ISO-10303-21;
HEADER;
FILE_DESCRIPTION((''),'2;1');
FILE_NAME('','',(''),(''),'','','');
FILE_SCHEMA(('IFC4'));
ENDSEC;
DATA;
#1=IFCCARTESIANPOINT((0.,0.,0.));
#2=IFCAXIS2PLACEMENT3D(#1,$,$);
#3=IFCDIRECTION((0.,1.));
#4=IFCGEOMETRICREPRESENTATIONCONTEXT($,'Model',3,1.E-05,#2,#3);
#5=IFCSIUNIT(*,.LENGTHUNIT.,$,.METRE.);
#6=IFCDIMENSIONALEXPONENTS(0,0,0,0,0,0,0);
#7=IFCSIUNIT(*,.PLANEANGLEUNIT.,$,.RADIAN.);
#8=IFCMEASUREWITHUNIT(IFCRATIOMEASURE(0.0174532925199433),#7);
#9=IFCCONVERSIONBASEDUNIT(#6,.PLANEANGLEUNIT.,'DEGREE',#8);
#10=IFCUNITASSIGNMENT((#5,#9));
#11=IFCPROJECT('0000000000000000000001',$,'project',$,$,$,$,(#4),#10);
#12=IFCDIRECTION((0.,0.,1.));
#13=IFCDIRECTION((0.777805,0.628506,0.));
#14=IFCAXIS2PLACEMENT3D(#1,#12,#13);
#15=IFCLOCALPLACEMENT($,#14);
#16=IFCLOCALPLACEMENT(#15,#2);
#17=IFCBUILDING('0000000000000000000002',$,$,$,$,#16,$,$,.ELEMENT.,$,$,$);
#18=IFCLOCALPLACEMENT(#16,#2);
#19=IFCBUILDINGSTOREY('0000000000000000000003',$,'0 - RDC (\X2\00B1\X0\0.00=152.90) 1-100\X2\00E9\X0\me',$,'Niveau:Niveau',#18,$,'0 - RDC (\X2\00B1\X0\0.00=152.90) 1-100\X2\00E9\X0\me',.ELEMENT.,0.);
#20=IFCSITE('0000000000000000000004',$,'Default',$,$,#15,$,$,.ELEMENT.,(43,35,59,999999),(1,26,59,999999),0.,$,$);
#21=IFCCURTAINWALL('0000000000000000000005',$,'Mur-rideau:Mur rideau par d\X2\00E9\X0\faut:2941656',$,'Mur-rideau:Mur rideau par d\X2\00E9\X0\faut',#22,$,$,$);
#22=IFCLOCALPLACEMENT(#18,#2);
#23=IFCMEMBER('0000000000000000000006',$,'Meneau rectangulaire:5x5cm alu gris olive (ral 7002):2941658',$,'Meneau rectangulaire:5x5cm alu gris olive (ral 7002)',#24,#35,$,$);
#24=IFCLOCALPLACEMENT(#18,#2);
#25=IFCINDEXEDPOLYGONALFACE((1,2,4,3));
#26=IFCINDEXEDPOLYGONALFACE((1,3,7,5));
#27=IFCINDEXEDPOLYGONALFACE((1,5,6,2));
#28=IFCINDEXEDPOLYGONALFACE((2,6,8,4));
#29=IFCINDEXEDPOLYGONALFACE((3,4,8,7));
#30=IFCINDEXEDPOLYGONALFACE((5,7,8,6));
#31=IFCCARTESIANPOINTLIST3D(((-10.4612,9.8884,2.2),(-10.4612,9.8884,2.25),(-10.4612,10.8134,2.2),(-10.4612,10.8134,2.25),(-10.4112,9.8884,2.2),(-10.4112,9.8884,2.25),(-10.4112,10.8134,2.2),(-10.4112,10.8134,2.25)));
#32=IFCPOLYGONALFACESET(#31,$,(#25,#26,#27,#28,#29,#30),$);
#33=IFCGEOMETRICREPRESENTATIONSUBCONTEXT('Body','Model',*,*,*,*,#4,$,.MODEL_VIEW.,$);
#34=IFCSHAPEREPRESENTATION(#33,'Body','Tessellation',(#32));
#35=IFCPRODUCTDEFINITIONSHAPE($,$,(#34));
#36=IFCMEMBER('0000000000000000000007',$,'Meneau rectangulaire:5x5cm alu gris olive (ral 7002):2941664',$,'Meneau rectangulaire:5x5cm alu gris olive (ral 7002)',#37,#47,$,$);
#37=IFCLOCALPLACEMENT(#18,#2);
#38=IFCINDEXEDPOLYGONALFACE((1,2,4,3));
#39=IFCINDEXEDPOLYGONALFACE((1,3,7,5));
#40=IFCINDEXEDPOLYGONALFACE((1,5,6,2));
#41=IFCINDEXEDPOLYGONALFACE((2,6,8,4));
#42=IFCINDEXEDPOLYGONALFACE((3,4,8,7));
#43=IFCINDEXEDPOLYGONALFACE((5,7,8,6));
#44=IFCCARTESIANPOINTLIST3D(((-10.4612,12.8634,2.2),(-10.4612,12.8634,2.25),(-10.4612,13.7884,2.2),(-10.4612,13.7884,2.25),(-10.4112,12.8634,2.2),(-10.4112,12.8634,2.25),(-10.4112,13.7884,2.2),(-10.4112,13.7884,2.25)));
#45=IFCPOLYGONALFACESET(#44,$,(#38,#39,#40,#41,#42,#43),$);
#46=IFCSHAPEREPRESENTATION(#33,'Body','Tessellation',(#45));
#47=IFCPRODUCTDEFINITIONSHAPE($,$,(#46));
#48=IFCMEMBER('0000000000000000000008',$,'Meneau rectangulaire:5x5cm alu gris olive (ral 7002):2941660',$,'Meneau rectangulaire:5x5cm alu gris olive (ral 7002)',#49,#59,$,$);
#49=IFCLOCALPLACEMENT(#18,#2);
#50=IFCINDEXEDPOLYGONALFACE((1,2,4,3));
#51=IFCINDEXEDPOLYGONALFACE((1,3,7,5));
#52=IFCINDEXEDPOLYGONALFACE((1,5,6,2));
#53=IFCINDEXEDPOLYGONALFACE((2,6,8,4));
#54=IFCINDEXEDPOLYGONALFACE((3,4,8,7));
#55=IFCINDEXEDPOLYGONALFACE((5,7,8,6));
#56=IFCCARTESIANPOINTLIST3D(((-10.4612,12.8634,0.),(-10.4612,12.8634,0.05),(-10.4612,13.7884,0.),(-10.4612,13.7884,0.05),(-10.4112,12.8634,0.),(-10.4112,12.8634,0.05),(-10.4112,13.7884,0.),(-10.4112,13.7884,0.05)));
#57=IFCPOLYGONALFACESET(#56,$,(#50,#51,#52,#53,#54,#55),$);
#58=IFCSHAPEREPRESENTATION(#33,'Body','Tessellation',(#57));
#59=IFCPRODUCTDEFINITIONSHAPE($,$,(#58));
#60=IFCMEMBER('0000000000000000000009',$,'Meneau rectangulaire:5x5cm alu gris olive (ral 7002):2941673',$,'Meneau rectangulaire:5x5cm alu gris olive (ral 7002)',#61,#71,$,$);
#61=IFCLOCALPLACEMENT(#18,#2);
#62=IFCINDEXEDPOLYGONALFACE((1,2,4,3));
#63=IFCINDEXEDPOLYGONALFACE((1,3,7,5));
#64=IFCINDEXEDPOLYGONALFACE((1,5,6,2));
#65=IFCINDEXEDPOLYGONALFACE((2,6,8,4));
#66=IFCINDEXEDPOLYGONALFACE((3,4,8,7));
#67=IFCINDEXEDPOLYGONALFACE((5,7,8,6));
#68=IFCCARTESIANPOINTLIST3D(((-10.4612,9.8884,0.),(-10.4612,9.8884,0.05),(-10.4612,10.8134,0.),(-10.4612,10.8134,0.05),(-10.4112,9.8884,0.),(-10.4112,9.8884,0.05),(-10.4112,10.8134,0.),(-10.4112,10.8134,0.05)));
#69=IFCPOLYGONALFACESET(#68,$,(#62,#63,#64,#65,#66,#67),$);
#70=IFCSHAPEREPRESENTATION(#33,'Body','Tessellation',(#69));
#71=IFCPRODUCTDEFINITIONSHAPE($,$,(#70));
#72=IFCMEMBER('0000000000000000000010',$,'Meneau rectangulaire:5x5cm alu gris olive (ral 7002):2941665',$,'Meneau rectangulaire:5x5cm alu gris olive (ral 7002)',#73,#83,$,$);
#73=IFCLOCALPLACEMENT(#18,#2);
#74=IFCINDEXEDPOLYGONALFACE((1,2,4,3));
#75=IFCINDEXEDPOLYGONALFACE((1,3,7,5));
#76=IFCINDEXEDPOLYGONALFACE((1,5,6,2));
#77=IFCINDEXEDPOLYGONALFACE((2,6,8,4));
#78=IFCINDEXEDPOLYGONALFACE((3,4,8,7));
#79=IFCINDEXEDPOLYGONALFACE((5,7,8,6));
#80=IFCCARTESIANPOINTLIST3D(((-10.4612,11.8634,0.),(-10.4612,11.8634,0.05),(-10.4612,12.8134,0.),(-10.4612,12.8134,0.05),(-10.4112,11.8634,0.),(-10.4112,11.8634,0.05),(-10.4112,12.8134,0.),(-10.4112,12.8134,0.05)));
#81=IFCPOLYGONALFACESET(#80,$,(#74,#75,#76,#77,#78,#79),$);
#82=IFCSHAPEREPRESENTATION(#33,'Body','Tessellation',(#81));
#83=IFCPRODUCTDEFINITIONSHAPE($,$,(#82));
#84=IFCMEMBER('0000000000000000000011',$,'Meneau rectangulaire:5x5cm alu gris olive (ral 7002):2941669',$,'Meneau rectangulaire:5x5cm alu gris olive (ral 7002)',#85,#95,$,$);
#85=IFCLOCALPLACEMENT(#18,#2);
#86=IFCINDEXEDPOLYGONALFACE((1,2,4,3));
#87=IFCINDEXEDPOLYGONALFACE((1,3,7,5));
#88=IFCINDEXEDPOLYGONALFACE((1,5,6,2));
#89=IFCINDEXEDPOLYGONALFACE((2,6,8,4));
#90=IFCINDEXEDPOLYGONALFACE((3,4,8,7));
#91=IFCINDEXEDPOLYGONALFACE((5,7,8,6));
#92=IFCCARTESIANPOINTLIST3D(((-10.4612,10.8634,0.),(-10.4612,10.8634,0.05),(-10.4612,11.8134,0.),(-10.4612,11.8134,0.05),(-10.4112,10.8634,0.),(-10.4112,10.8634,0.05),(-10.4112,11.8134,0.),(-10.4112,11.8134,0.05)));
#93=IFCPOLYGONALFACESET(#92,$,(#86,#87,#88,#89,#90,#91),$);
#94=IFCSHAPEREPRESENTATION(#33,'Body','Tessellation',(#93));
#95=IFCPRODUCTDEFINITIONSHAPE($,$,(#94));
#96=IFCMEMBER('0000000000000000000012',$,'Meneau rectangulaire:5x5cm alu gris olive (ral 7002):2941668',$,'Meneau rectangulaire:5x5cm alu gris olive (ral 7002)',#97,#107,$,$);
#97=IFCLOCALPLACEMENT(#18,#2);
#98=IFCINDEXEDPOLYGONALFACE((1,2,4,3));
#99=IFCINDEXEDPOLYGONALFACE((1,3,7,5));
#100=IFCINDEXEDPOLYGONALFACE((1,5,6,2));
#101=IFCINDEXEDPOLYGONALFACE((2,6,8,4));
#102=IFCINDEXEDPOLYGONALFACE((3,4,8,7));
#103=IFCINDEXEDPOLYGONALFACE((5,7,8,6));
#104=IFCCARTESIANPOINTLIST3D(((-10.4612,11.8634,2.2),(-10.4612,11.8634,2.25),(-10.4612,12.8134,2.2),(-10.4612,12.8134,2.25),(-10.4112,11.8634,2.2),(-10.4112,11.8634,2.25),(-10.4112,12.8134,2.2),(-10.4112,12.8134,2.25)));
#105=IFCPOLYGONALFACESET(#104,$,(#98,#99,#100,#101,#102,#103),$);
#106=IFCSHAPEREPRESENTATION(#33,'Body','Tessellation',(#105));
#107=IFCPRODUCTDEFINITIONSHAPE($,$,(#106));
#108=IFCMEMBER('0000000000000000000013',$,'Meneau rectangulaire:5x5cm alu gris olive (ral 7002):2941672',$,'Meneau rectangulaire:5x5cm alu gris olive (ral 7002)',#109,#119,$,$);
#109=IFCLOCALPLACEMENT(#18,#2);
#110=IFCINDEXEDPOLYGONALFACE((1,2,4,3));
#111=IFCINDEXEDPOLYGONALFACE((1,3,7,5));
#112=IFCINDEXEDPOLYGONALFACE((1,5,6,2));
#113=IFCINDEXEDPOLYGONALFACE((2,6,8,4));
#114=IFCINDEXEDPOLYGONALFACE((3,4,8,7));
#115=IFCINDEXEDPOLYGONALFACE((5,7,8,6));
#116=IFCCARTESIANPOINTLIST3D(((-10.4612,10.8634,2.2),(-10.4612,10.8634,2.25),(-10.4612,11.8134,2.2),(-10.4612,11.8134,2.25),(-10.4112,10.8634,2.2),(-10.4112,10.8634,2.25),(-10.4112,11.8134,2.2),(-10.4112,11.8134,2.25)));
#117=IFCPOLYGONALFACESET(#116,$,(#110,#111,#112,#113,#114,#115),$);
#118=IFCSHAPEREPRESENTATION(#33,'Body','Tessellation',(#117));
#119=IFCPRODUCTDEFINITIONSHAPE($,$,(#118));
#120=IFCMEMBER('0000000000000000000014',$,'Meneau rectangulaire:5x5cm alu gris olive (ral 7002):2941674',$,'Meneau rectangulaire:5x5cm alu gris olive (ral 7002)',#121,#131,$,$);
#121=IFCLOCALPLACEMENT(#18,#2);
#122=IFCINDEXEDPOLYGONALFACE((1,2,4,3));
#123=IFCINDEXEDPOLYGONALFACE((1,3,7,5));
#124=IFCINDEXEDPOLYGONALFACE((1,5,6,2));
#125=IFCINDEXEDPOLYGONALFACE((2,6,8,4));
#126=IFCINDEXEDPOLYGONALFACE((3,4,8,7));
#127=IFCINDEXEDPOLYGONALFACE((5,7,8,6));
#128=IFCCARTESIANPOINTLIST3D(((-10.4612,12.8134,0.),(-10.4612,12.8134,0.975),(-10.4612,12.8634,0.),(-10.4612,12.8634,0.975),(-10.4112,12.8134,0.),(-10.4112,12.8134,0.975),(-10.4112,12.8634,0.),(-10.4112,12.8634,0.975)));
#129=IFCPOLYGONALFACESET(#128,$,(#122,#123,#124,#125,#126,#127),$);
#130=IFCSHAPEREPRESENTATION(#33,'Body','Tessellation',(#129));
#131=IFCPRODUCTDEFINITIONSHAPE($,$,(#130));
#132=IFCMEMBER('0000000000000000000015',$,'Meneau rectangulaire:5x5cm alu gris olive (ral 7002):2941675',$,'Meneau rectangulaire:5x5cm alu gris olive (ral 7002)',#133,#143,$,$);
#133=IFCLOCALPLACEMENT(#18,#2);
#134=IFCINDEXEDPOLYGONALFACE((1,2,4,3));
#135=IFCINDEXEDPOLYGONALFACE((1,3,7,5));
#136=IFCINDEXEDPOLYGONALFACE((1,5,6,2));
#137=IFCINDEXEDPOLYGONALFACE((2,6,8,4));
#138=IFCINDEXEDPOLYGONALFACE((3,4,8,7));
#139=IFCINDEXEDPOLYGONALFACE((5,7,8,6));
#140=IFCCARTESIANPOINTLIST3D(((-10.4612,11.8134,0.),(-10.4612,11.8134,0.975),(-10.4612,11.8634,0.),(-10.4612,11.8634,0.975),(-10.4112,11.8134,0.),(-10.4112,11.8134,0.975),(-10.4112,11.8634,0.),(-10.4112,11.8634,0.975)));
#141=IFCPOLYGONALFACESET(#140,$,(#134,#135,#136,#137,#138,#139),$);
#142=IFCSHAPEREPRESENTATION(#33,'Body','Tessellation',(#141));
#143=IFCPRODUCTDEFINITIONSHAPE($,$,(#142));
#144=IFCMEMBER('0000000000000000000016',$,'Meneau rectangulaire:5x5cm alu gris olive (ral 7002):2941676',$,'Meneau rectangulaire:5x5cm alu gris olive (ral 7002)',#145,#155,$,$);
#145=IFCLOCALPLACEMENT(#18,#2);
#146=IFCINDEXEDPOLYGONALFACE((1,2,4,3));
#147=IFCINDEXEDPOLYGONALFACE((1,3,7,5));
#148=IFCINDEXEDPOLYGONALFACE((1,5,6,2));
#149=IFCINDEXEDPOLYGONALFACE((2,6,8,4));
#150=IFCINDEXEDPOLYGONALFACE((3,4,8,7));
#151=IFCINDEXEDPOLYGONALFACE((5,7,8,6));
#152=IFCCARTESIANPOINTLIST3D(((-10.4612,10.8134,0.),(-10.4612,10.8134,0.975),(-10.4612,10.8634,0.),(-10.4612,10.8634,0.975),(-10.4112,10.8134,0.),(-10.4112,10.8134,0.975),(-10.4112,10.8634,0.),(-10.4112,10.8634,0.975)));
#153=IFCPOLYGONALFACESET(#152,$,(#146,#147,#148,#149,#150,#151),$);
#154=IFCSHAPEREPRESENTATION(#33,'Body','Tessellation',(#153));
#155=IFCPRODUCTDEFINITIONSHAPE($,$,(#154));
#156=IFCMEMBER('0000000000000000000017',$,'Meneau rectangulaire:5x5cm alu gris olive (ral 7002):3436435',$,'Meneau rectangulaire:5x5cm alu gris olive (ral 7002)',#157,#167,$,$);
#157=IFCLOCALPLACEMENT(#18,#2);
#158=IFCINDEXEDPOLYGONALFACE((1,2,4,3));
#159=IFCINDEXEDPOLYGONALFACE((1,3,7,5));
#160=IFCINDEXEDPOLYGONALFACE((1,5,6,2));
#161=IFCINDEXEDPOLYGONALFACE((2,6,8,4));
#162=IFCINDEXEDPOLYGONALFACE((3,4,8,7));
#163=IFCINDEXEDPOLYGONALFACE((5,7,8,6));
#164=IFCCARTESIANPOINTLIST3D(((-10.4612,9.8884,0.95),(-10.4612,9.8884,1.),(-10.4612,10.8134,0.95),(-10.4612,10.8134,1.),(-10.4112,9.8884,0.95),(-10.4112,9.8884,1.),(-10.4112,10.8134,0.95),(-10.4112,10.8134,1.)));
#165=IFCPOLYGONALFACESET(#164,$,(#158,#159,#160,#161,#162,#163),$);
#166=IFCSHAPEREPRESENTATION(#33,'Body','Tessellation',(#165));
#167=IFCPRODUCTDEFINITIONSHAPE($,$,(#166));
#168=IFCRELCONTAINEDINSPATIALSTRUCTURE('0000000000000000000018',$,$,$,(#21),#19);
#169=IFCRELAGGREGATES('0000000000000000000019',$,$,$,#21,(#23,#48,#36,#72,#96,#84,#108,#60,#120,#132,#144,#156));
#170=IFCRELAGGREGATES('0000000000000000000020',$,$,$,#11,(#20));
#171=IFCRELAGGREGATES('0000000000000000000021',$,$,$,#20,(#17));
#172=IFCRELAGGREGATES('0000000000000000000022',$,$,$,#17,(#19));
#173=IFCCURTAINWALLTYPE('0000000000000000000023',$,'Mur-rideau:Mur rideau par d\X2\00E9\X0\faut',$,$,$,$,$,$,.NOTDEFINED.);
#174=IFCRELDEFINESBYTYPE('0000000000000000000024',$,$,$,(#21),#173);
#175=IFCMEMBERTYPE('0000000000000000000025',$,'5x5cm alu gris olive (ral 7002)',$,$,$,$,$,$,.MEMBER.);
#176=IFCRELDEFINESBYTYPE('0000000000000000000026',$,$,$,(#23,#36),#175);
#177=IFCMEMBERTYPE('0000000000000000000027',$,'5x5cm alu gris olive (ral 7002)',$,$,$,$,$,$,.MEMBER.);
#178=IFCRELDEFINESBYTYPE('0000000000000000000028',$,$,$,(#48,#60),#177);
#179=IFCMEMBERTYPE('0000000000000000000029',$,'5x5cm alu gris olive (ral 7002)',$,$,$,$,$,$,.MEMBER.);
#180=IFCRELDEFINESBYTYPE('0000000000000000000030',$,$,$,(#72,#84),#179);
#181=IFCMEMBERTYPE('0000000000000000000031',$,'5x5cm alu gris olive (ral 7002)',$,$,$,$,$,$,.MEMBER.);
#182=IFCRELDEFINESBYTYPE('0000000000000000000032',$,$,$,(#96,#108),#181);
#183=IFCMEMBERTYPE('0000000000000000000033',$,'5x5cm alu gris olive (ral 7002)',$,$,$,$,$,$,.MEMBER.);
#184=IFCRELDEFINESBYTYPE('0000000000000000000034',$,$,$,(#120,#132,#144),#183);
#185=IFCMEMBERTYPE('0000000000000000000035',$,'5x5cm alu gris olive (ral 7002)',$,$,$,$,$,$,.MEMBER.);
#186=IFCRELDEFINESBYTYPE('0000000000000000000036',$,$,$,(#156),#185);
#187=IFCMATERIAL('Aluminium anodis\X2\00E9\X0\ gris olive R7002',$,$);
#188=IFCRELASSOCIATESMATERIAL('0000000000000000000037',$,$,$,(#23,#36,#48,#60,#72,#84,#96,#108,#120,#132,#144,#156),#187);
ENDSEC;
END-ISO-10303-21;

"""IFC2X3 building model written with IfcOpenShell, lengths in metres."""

from ifc_helpers import new_model, entity, si_unit, converted_unit, direction, frame, origin, origin_2d_with_axis, place, context, subcontext, project, spatial, rectangle, extrude, source, transform, mapped, material, type_object, type_shapes, element, aggregate, save


model = new_model("IFC2X3")

# Units and contexts
model_context = context("Model", 3, precision=1e-05, world=origin(), true_north=direction((0.0, 1.0)))
body_context = subcontext(model_context, "Body", "Model", "MODEL_VIEW")
ifc_project = project(units=[si_unit("LENGTHUNIT", "METRE"), converted_unit("PLANEANGLEUNIT", "DEGREE", entity("IfcRatioMeasure", 0.0174532925199433), si_unit("PLANEANGLEUNIT", "RADIAN"), dimensions=[0, 0, 0, 0, 0, 0, 0])], contexts=[model_context])

# Site, building, storey
site_placement = place(None, frame((0.0, 0.0, 0.0), z_axis=(0.0, 0.0, 1.0), x_axis=(0.777805, 0.628506, 0.0)))
site = spatial("IfcSite", under=ifc_project, at=site_placement, Name="Default", CompositionType="ELEMENT", RefLatitude=(43, 35, 59, 999999), RefLongitude=(1, 26, 59, 999999), RefElevation=0.0)
building_placement = place(site_placement, origin())
building = spatial("IfcBuilding", under=site, at=building_placement, CompositionType="ELEMENT")
storey_placement = place(building_placement, origin())
storey = spatial("IfcBuildingStorey", under=building, at=storey_placement, Name="0 - RDC (±0.00=152.90) 1-100éme", ObjectType="Niveau:Niveau", LongName="0 - RDC (±0.00=152.90) 1-100éme", CompositionType="ELEMENT", Elevation=0.0)

# Curtain wall, members
curtain_wall_type = type_object("IfcCurtainWallType", Name="Mur-rideau:Mur rideau par défaut", PredefinedType="NOTDEFINED")
curtain_wall_placement = place(storey_placement, origin())
curtain_wall = element("IfcCurtainWall", 1, at=curtain_wall_placement, inside=storey, type_object=curtain_wall_type, Name="Mur-rideau:Mur rideau par défaut:2941656", ObjectType="Mur-rideau:Mur rideau par défaut")
ifc_material_1 = material(Name="Aluminium anodisé gris olive R7002")
member_type_1 = type_object("IfcMemberType", Name="5x5cm alu gris olive (ral 7002)", PredefinedType="MEMBER")
shared_shape_1 = source(origin(), body_context, "Body", "SweptSolid", [
    extrude(rectangle(XDim=0.05, YDim=0.05, at=origin_2d_with_axis()), frame((-0.025, 0.0, -0.925), z_axis=(0.0, 0.0, 1.0), x_axis=(0.0, -1.0, 0.0)), (0.0, 0.0, 1.0), 0.925),
])
type_shapes(member_type_1, [shared_shape_1])
member_1_placement = place(storey_placement, frame((-10.4362, 9.8884, 2.25), z_axis=(0.0, -1.0, 0.0), x_axis=(0.0, 0.0, 1.0)))
member_1 = element("IfcMember", 2, at=member_1_placement, type_object=member_type_1, material=ifc_material_1, Name="Meneau rectangulaire:5x5cm alu gris olive (ral 7002):2941658", ObjectType="Meneau rectangulaire:5x5cm alu gris olive (ral 7002)", context=body_context, shape_type="MappedRepresentation", body=[
    mapped(shared_shape_1, transform((0.0, 0.0, 0.0), scale=1.0)),
])
member_2_placement = place(storey_placement, frame((-10.4362, 12.8634, 2.25), z_axis=(0.0, -1.0, 0.0), x_axis=(0.0, 0.0, 1.0)))
member_2 = element("IfcMember", 3, at=member_2_placement, type_object=member_type_1, material=ifc_material_1, Name="Meneau rectangulaire:5x5cm alu gris olive (ral 7002):2941664", ObjectType="Meneau rectangulaire:5x5cm alu gris olive (ral 7002)", context=body_context, shape_type="MappedRepresentation", body=[
    mapped(shared_shape_1, transform((0.0, 0.0, 0.0), scale=1.0)),
])
member_type_2 = type_object("IfcMemberType", Name="5x5cm alu gris olive (ral 7002)", PredefinedType="MEMBER")
shared_shape_2 = source(origin(), body_context, "Body", "SweptSolid", [
    extrude(rectangle(XDim=0.05, YDim=0.05, at=origin_2d_with_axis()), frame((-0.025, 0.0, -0.925), z_axis=(0.0, 0.0, 1.0), x_axis=(0.0, -1.0, 0.0)), (0.0, 0.0, 1.0), 0.925),
])
type_shapes(member_type_2, [shared_shape_2])
member_3_placement = place(storey_placement, frame((-10.4362, 13.7884, 0.0), z_axis=(0.0, 1.0, 0.0), x_axis=(0.0, 0.0, -1.0)))
member_3 = element("IfcMember", 4, at=member_3_placement, type_object=member_type_2, material=ifc_material_1, Name="Meneau rectangulaire:5x5cm alu gris olive (ral 7002):2941660", ObjectType="Meneau rectangulaire:5x5cm alu gris olive (ral 7002)", context=body_context, shape_type="MappedRepresentation", body=[
    mapped(shared_shape_2, transform((0.0, 0.0, 0.0), scale=1.0)),
])
member_4_placement = place(storey_placement, frame((-10.4362, 10.8134, 0.0), z_axis=(0.0, 1.0, 0.0), x_axis=(0.0, 0.0, -1.0)))
member_4 = element("IfcMember", 5, at=member_4_placement, type_object=member_type_2, material=ifc_material_1, Name="Meneau rectangulaire:5x5cm alu gris olive (ral 7002):2941673", ObjectType="Meneau rectangulaire:5x5cm alu gris olive (ral 7002)", context=body_context, shape_type="MappedRepresentation", body=[
    mapped(shared_shape_2, transform((0.0, 0.0, 0.0), scale=1.0)),
])
member_type_3 = type_object("IfcMemberType", Name="5x5cm alu gris olive (ral 7002)", PredefinedType="MEMBER")
shared_shape_3 = source(origin(), body_context, "Body", "SweptSolid", [
    extrude(rectangle(XDim=0.05, YDim=0.05, at=origin_2d_with_axis()), frame((-0.025, 0.0, -0.95), z_axis=(0.0, 0.0, 1.0), x_axis=(0.0, -1.0, 0.0)), (0.0, 0.0, 1.0), 0.95),
])
type_shapes(member_type_3, [shared_shape_3])
member_5_placement = place(storey_placement, frame((-10.4362, 12.8134, 0.0), z_axis=(0.0, 1.0, 0.0), x_axis=(0.0, 0.0, -1.0)))
member_5 = element("IfcMember", 6, at=member_5_placement, type_object=member_type_3, material=ifc_material_1, Name="Meneau rectangulaire:5x5cm alu gris olive (ral 7002):2941665", ObjectType="Meneau rectangulaire:5x5cm alu gris olive (ral 7002)", context=body_context, shape_type="MappedRepresentation", body=[
    mapped(shared_shape_3, transform((0.0, 0.0, 0.0), scale=1.0)),
])
member_6_placement = place(storey_placement, frame((-10.4362, 11.8134, 0.0), z_axis=(0.0, 1.0, 0.0), x_axis=(0.0, 0.0, -1.0)))
member_6 = element("IfcMember", 7, at=member_6_placement, type_object=member_type_3, material=ifc_material_1, Name="Meneau rectangulaire:5x5cm alu gris olive (ral 7002):2941669", ObjectType="Meneau rectangulaire:5x5cm alu gris olive (ral 7002)", context=body_context, shape_type="MappedRepresentation", body=[
    mapped(shared_shape_3, transform((0.0, 0.0, 0.0), scale=1.0)),
])
member_type_4 = type_object("IfcMemberType", Name="5x5cm alu gris olive (ral 7002)", PredefinedType="MEMBER")
shared_shape_4 = source(origin(), body_context, "Body", "SweptSolid", [
    extrude(rectangle(XDim=0.05, YDim=0.05, at=origin_2d_with_axis()), frame((-0.025, 0.0, -0.95), z_axis=(0.0, 0.0, 1.0), x_axis=(0.0, -1.0, 0.0)), (0.0, 0.0, 1.0), 0.95),
])
type_shapes(member_type_4, [shared_shape_4])
member_7_placement = place(storey_placement, frame((-10.4362, 11.8634, 2.25), z_axis=(0.0, -1.0, 0.0), x_axis=(0.0, 0.0, 1.0)))
member_7 = element("IfcMember", 8, at=member_7_placement, type_object=member_type_4, material=ifc_material_1, Name="Meneau rectangulaire:5x5cm alu gris olive (ral 7002):2941668", ObjectType="Meneau rectangulaire:5x5cm alu gris olive (ral 7002)", context=body_context, shape_type="MappedRepresentation", body=[
    mapped(shared_shape_4, transform((0.0, 0.0, 0.0), scale=1.0)),
])
member_8_placement = place(storey_placement, frame((-10.4362, 10.8634, 2.25), z_axis=(0.0, -1.0, 0.0), x_axis=(0.0, 0.0, 1.0)))
member_8 = element("IfcMember", 9, at=member_8_placement, type_object=member_type_4, material=ifc_material_1, Name="Meneau rectangulaire:5x5cm alu gris olive (ral 7002):2941672", ObjectType="Meneau rectangulaire:5x5cm alu gris olive (ral 7002)", context=body_context, shape_type="MappedRepresentation", body=[
    mapped(shared_shape_4, transform((0.0, 0.0, 0.0), scale=1.0)),
])
member_type_5 = type_object("IfcMemberType", Name="5x5cm alu gris olive (ral 7002)", PredefinedType="MEMBER")
shared_shape_5 = source(origin(), body_context, "Body", "SweptSolid", [
    extrude(rectangle(XDim=0.05, YDim=0.05, at=origin_2d_with_axis()), frame((0.0, 0.0, -0.975), z_axis=(0.0, 0.0, 1.0), x_axis=(0.0, -1.0, 0.0)), (0.0, 0.0, 1.0), 0.975),
])
type_shapes(member_type_5, [shared_shape_5])
member_9_placement = place(storey_placement, frame((-10.4362, 12.8384, 0.0), z_axis=(0.0, 0.0, -1.0), x_axis=(0.0, -1.0, 0.0)))
member_9 = element("IfcMember", 10, at=member_9_placement, type_object=member_type_5, material=ifc_material_1, Name="Meneau rectangulaire:5x5cm alu gris olive (ral 7002):2941674", ObjectType="Meneau rectangulaire:5x5cm alu gris olive (ral 7002)", context=body_context, shape_type="MappedRepresentation", body=[
    mapped(shared_shape_5, transform((0.0, 0.0, 0.0), scale=1.0)),
])
member_10_placement = place(storey_placement, frame((-10.4362, 11.8384, 0.0), z_axis=(0.0, 0.0, -1.0), x_axis=(0.0, -1.0, 0.0)))
member_10 = element("IfcMember", 11, at=member_10_placement, type_object=member_type_5, material=ifc_material_1, Name="Meneau rectangulaire:5x5cm alu gris olive (ral 7002):2941675", ObjectType="Meneau rectangulaire:5x5cm alu gris olive (ral 7002)", context=body_context, shape_type="MappedRepresentation", body=[
    mapped(shared_shape_5, transform((0.0, 0.0, 0.0), scale=1.0)),
])
member_11_placement = place(storey_placement, frame((-10.4362, 10.8384, 0.0), z_axis=(0.0, 0.0, -1.0), x_axis=(0.0, -1.0, 0.0)))
member_11 = element("IfcMember", 12, at=member_11_placement, type_object=member_type_5, material=ifc_material_1, Name="Meneau rectangulaire:5x5cm alu gris olive (ral 7002):2941676", ObjectType="Meneau rectangulaire:5x5cm alu gris olive (ral 7002)", context=body_context, shape_type="MappedRepresentation", body=[
    mapped(shared_shape_5, transform((0.0, 0.0, 0.0), scale=1.0)),
])
member_type_6 = type_object("IfcMemberType", Name="5x5cm alu gris olive (ral 7002)", PredefinedType="MEMBER")
shared_shape_6 = source(origin(), body_context, "Body", "SweptSolid", [
    extrude(rectangle(XDim=0.05, YDim=0.05, at=origin_2d_with_axis()), frame((0.0, 0.0, -0.925), z_axis=(0.0, 0.0, 1.0), x_axis=(0.0, -1.0, 0.0)), (0.0, 0.0, 1.0), 0.925),
])
type_shapes(member_type_6, [shared_shape_6])
member_12_placement = place(storey_placement, frame((-10.4362, 9.8884, 0.975), z_axis=(0.0, -1.0, 0.0), x_axis=(0.0, 0.0, 1.0)))
member_12 = element("IfcMember", 13, at=member_12_placement, type_object=member_type_6, material=ifc_material_1, Name="Meneau rectangulaire:5x5cm alu gris olive (ral 7002):3436435", ObjectType="Meneau rectangulaire:5x5cm alu gris olive (ral 7002)", context=body_context, shape_type="MappedRepresentation", body=[
    mapped(shared_shape_6, transform((0.0, 0.0, 0.0), scale=1.0)),
])
aggregate(curtain_wall, [member_1, member_3, member_2, member_5, member_7, member_6, member_8, member_4, member_9, member_10, member_11, member_12])

save(model, "model.ifc")
